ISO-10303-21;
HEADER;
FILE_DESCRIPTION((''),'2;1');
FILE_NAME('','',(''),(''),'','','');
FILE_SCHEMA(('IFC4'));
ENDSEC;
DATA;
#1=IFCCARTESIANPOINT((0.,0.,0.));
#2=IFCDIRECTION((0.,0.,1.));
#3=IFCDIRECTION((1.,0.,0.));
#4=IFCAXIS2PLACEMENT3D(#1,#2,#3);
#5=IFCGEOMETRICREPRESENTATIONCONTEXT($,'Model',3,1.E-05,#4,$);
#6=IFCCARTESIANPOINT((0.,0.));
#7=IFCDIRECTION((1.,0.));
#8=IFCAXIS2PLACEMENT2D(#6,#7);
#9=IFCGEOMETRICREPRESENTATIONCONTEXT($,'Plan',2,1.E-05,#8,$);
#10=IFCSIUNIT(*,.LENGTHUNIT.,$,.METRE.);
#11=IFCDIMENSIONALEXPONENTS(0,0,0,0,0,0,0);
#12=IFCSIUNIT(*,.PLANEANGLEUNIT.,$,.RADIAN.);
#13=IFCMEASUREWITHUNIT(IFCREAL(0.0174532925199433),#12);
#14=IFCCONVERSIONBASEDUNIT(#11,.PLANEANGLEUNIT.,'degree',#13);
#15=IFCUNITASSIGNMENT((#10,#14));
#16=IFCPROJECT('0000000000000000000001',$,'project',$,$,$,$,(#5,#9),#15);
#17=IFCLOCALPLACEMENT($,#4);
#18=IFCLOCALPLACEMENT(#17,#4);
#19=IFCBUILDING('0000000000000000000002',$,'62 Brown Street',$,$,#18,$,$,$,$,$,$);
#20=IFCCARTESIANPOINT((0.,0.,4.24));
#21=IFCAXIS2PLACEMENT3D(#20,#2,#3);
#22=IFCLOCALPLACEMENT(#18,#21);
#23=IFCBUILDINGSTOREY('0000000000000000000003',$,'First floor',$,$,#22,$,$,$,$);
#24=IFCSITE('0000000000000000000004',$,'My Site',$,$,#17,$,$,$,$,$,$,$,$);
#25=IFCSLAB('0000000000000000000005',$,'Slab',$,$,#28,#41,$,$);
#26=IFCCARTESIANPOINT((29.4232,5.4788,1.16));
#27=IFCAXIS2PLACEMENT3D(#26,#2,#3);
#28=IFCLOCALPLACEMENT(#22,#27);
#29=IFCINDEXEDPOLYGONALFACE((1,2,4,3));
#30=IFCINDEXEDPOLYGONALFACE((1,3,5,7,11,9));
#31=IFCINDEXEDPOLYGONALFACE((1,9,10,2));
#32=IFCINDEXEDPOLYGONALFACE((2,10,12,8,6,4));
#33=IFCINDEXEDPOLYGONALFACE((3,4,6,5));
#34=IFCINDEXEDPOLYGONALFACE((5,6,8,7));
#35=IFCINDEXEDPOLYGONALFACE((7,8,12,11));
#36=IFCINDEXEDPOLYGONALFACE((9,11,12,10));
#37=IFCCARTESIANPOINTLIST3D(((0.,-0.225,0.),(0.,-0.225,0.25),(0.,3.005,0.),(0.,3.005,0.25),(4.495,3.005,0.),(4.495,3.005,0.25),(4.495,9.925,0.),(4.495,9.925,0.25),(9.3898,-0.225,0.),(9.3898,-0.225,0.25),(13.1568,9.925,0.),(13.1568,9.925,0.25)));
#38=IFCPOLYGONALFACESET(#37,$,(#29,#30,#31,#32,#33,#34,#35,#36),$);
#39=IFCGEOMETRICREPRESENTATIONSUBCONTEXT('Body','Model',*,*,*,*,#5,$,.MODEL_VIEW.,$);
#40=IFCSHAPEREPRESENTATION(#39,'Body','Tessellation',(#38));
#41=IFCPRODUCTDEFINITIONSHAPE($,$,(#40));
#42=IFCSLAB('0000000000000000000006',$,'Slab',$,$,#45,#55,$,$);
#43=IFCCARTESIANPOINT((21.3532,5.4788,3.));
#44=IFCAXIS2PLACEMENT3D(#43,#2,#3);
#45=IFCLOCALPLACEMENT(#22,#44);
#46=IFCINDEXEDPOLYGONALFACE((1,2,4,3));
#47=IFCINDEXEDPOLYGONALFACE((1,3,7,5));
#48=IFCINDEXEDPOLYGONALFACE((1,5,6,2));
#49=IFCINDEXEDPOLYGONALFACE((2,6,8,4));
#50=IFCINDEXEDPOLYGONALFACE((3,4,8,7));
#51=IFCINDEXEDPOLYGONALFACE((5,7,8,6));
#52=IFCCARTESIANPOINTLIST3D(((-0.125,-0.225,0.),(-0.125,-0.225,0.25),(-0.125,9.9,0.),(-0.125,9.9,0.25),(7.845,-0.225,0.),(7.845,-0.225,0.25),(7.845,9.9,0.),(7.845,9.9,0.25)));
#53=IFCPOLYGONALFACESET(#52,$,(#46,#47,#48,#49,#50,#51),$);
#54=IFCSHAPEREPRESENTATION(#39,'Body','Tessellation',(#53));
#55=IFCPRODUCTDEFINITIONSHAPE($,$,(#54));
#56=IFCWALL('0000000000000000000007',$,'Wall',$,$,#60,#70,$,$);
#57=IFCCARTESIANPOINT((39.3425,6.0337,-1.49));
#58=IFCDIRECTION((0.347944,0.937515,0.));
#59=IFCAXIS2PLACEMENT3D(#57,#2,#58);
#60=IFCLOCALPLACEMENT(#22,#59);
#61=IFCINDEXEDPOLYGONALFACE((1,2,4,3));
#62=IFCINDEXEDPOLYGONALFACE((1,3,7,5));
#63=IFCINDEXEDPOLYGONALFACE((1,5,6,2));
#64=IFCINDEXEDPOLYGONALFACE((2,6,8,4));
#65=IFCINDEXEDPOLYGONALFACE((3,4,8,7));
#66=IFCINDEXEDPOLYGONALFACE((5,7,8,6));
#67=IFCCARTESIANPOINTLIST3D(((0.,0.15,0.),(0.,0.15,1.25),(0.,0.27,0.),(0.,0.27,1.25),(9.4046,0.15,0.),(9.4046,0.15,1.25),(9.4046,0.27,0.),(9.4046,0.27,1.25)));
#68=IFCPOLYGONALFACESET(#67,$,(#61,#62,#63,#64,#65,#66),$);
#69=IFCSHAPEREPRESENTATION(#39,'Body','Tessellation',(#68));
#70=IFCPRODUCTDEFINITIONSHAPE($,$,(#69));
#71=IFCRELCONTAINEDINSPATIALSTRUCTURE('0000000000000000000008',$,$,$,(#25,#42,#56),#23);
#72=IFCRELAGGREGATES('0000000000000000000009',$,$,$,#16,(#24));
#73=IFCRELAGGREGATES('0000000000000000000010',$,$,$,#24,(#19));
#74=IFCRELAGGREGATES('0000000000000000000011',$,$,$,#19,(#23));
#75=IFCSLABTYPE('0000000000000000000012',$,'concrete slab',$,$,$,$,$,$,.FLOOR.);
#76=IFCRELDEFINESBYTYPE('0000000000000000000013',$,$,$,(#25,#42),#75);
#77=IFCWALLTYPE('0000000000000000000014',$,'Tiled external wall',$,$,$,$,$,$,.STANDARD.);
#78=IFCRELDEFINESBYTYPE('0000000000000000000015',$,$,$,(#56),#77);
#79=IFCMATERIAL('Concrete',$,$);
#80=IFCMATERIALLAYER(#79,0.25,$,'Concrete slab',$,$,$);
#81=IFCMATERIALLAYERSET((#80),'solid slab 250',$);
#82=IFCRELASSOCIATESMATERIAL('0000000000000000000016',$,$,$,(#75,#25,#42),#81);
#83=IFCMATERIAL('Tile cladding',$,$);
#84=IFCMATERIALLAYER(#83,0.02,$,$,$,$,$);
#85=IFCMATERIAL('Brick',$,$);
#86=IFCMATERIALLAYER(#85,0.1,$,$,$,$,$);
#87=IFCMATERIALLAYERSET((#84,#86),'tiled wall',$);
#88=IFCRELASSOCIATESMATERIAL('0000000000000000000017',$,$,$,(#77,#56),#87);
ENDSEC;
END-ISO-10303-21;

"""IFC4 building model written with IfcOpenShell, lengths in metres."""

from ifc_helpers import new_model, entity, si_unit, converted_unit, frame, origin_with_axes, origin_2d_with_axis, place, context, subcontext, project, spatial, line, indexed_curve, outline, extrude, material, layer, layer_set, layer_usage, type_object, element, save


model = new_model("IFC4")

# Units and contexts
model_context = context("Model", 3, precision=1e-05, world=origin_with_axes())
plan_context = context("Plan", 2, precision=1e-05, world=origin_2d_with_axis())
body_context_1 = subcontext(model_context, "Body", "Model", "MODEL_VIEW")
ifc_project = project(units=[si_unit("LENGTHUNIT", "METRE"), converted_unit("PLANEANGLEUNIT", "degree", entity("IfcReal", 0.0174532925199433), si_unit("PLANEANGLEUNIT", "RADIAN"), dimensions=[0, 0, 0, 0, 0, 0, 0])], contexts=[model_context, plan_context])

# Site, building, storey
site_placement = place(None, origin_with_axes())
site = spatial("IfcSite", under=ifc_project, at=site_placement, Name="My Site")
building_placement = place(site_placement, origin_with_axes())
building = spatial("IfcBuilding", under=site, at=building_placement, Name="62 Brown Street")
storey_placement = place(building_placement, frame((0.0, 0.0, 4.24), z_axis=(0.0, 0.0, 1.0), x_axis=(1.0, 0.0, 0.0)))
storey = spatial("IfcBuildingStorey", under=building, at=storey_placement, Name="First floor")

# Slabs
ifc_material_1 = material(Name="Concrete")
ifc_layer_1 = layer(ifc_material_1, 0.25, Name="Concrete slab")
ifc_layer_set_1 = layer_set([ifc_layer_1], Name="solid slab 250")
slab_type = type_object("IfcSlabType", Name="concrete slab", PredefinedType="FLOOR", material=ifc_layer_set_1)
ifc_layer_usage_1 = layer_usage(ifc_layer_set_1, "AXIS3", "POSITIVE", 0.0)
slab_1_placement = place(storey_placement, frame((29.4232, 5.4788, 1.16), z_axis=(0.0, 0.0, 1.0), x_axis=(1.0, 0.0, 0.0)))
element("IfcSlab", 1, at=slab_1_placement, inside=storey, type_object=slab_type, material=ifc_layer_usage_1, Name="Slab", context=body_context_1, shape_type="SweptSolid", body=[
    extrude(outline(indexed_curve([(0.0, 3.005), (0.0, -0.225), (9.3898, -0.225), (13.1568, 9.925), (4.495, 9.925), (4.495, 3.005)], segments=[line(4, 3), line(3, 2), line(2, 1), line(1, 6), line(6, 5), line(5, 4)], self_intersect=False)), None, (0.0, 0.0, 1.0), 0.25),
])
ifc_layer_usage_2 = layer_usage(ifc_layer_set_1, "AXIS3", "POSITIVE", 0.0)
slab_2_placement = place(storey_placement, frame((21.3532, 5.4788, 3.0), z_axis=(0.0, 0.0, 1.0), x_axis=(1.0, 0.0, 0.0)))
element("IfcSlab", 2, at=slab_2_placement, inside=storey, type_object=slab_type, material=ifc_layer_usage_2, Name="Slab", context=body_context_1, shape_type="SweptSolid", body=[
    extrude(outline(indexed_curve([(7.845, -0.225), (-0.125, -0.225), (-0.125, 9.9), (7.845, 9.9)], segments=[line(4, 1), line(1, 2), line(2, 3), line(3, 4)], self_intersect=False)), None, (0.0, 0.0, 1.0), 0.25),
])

# Shared definitions
ifc_material_2 = material(Name="Brick")

# Wall
ifc_material_3 = material(Name="Tile cladding")
ifc_layer_2 = layer(ifc_material_3, 0.02)
ifc_layer_3 = layer(ifc_material_2, 0.1)
ifc_layer_set_2 = layer_set([ifc_layer_2, ifc_layer_3], Name="tiled wall")
ifc_layer_usage_3 = layer_usage(ifc_layer_set_2, "AXIS2", "POSITIVE", 0.15)
wall_type_1 = type_object("IfcWallType", Name="Tiled external wall", PredefinedType="STANDARD", material=ifc_layer_set_2)
wall_1_placement = place(storey_placement, frame((39.3425, 6.0337, -1.49), z_axis=(0.0, 0.0, 1.0), x_axis=(0.347944, 0.937515, 0.0)))
element("IfcWall", 3, at=wall_1_placement, inside=storey, type_object=wall_type_1, material=ifc_layer_usage_3, Name="Wall", context=body_context_1, shape_type="SweptSolid", body=[
    extrude(outline(indexed_curve([(0.0, 0.0), (0.0, 0.12), (9.4046, 0.12), (9.4046, 0.0), (0.0, 0.0)], self_intersect=False)), frame((0.0, 0.15, 0.0), z_axis=(0.0, 0.0, 1.0), x_axis=(1.0, 0.0, 0.0)), (0.0, 0.0, 1.0), 1.25),
])

save(model, "model.ifc")
